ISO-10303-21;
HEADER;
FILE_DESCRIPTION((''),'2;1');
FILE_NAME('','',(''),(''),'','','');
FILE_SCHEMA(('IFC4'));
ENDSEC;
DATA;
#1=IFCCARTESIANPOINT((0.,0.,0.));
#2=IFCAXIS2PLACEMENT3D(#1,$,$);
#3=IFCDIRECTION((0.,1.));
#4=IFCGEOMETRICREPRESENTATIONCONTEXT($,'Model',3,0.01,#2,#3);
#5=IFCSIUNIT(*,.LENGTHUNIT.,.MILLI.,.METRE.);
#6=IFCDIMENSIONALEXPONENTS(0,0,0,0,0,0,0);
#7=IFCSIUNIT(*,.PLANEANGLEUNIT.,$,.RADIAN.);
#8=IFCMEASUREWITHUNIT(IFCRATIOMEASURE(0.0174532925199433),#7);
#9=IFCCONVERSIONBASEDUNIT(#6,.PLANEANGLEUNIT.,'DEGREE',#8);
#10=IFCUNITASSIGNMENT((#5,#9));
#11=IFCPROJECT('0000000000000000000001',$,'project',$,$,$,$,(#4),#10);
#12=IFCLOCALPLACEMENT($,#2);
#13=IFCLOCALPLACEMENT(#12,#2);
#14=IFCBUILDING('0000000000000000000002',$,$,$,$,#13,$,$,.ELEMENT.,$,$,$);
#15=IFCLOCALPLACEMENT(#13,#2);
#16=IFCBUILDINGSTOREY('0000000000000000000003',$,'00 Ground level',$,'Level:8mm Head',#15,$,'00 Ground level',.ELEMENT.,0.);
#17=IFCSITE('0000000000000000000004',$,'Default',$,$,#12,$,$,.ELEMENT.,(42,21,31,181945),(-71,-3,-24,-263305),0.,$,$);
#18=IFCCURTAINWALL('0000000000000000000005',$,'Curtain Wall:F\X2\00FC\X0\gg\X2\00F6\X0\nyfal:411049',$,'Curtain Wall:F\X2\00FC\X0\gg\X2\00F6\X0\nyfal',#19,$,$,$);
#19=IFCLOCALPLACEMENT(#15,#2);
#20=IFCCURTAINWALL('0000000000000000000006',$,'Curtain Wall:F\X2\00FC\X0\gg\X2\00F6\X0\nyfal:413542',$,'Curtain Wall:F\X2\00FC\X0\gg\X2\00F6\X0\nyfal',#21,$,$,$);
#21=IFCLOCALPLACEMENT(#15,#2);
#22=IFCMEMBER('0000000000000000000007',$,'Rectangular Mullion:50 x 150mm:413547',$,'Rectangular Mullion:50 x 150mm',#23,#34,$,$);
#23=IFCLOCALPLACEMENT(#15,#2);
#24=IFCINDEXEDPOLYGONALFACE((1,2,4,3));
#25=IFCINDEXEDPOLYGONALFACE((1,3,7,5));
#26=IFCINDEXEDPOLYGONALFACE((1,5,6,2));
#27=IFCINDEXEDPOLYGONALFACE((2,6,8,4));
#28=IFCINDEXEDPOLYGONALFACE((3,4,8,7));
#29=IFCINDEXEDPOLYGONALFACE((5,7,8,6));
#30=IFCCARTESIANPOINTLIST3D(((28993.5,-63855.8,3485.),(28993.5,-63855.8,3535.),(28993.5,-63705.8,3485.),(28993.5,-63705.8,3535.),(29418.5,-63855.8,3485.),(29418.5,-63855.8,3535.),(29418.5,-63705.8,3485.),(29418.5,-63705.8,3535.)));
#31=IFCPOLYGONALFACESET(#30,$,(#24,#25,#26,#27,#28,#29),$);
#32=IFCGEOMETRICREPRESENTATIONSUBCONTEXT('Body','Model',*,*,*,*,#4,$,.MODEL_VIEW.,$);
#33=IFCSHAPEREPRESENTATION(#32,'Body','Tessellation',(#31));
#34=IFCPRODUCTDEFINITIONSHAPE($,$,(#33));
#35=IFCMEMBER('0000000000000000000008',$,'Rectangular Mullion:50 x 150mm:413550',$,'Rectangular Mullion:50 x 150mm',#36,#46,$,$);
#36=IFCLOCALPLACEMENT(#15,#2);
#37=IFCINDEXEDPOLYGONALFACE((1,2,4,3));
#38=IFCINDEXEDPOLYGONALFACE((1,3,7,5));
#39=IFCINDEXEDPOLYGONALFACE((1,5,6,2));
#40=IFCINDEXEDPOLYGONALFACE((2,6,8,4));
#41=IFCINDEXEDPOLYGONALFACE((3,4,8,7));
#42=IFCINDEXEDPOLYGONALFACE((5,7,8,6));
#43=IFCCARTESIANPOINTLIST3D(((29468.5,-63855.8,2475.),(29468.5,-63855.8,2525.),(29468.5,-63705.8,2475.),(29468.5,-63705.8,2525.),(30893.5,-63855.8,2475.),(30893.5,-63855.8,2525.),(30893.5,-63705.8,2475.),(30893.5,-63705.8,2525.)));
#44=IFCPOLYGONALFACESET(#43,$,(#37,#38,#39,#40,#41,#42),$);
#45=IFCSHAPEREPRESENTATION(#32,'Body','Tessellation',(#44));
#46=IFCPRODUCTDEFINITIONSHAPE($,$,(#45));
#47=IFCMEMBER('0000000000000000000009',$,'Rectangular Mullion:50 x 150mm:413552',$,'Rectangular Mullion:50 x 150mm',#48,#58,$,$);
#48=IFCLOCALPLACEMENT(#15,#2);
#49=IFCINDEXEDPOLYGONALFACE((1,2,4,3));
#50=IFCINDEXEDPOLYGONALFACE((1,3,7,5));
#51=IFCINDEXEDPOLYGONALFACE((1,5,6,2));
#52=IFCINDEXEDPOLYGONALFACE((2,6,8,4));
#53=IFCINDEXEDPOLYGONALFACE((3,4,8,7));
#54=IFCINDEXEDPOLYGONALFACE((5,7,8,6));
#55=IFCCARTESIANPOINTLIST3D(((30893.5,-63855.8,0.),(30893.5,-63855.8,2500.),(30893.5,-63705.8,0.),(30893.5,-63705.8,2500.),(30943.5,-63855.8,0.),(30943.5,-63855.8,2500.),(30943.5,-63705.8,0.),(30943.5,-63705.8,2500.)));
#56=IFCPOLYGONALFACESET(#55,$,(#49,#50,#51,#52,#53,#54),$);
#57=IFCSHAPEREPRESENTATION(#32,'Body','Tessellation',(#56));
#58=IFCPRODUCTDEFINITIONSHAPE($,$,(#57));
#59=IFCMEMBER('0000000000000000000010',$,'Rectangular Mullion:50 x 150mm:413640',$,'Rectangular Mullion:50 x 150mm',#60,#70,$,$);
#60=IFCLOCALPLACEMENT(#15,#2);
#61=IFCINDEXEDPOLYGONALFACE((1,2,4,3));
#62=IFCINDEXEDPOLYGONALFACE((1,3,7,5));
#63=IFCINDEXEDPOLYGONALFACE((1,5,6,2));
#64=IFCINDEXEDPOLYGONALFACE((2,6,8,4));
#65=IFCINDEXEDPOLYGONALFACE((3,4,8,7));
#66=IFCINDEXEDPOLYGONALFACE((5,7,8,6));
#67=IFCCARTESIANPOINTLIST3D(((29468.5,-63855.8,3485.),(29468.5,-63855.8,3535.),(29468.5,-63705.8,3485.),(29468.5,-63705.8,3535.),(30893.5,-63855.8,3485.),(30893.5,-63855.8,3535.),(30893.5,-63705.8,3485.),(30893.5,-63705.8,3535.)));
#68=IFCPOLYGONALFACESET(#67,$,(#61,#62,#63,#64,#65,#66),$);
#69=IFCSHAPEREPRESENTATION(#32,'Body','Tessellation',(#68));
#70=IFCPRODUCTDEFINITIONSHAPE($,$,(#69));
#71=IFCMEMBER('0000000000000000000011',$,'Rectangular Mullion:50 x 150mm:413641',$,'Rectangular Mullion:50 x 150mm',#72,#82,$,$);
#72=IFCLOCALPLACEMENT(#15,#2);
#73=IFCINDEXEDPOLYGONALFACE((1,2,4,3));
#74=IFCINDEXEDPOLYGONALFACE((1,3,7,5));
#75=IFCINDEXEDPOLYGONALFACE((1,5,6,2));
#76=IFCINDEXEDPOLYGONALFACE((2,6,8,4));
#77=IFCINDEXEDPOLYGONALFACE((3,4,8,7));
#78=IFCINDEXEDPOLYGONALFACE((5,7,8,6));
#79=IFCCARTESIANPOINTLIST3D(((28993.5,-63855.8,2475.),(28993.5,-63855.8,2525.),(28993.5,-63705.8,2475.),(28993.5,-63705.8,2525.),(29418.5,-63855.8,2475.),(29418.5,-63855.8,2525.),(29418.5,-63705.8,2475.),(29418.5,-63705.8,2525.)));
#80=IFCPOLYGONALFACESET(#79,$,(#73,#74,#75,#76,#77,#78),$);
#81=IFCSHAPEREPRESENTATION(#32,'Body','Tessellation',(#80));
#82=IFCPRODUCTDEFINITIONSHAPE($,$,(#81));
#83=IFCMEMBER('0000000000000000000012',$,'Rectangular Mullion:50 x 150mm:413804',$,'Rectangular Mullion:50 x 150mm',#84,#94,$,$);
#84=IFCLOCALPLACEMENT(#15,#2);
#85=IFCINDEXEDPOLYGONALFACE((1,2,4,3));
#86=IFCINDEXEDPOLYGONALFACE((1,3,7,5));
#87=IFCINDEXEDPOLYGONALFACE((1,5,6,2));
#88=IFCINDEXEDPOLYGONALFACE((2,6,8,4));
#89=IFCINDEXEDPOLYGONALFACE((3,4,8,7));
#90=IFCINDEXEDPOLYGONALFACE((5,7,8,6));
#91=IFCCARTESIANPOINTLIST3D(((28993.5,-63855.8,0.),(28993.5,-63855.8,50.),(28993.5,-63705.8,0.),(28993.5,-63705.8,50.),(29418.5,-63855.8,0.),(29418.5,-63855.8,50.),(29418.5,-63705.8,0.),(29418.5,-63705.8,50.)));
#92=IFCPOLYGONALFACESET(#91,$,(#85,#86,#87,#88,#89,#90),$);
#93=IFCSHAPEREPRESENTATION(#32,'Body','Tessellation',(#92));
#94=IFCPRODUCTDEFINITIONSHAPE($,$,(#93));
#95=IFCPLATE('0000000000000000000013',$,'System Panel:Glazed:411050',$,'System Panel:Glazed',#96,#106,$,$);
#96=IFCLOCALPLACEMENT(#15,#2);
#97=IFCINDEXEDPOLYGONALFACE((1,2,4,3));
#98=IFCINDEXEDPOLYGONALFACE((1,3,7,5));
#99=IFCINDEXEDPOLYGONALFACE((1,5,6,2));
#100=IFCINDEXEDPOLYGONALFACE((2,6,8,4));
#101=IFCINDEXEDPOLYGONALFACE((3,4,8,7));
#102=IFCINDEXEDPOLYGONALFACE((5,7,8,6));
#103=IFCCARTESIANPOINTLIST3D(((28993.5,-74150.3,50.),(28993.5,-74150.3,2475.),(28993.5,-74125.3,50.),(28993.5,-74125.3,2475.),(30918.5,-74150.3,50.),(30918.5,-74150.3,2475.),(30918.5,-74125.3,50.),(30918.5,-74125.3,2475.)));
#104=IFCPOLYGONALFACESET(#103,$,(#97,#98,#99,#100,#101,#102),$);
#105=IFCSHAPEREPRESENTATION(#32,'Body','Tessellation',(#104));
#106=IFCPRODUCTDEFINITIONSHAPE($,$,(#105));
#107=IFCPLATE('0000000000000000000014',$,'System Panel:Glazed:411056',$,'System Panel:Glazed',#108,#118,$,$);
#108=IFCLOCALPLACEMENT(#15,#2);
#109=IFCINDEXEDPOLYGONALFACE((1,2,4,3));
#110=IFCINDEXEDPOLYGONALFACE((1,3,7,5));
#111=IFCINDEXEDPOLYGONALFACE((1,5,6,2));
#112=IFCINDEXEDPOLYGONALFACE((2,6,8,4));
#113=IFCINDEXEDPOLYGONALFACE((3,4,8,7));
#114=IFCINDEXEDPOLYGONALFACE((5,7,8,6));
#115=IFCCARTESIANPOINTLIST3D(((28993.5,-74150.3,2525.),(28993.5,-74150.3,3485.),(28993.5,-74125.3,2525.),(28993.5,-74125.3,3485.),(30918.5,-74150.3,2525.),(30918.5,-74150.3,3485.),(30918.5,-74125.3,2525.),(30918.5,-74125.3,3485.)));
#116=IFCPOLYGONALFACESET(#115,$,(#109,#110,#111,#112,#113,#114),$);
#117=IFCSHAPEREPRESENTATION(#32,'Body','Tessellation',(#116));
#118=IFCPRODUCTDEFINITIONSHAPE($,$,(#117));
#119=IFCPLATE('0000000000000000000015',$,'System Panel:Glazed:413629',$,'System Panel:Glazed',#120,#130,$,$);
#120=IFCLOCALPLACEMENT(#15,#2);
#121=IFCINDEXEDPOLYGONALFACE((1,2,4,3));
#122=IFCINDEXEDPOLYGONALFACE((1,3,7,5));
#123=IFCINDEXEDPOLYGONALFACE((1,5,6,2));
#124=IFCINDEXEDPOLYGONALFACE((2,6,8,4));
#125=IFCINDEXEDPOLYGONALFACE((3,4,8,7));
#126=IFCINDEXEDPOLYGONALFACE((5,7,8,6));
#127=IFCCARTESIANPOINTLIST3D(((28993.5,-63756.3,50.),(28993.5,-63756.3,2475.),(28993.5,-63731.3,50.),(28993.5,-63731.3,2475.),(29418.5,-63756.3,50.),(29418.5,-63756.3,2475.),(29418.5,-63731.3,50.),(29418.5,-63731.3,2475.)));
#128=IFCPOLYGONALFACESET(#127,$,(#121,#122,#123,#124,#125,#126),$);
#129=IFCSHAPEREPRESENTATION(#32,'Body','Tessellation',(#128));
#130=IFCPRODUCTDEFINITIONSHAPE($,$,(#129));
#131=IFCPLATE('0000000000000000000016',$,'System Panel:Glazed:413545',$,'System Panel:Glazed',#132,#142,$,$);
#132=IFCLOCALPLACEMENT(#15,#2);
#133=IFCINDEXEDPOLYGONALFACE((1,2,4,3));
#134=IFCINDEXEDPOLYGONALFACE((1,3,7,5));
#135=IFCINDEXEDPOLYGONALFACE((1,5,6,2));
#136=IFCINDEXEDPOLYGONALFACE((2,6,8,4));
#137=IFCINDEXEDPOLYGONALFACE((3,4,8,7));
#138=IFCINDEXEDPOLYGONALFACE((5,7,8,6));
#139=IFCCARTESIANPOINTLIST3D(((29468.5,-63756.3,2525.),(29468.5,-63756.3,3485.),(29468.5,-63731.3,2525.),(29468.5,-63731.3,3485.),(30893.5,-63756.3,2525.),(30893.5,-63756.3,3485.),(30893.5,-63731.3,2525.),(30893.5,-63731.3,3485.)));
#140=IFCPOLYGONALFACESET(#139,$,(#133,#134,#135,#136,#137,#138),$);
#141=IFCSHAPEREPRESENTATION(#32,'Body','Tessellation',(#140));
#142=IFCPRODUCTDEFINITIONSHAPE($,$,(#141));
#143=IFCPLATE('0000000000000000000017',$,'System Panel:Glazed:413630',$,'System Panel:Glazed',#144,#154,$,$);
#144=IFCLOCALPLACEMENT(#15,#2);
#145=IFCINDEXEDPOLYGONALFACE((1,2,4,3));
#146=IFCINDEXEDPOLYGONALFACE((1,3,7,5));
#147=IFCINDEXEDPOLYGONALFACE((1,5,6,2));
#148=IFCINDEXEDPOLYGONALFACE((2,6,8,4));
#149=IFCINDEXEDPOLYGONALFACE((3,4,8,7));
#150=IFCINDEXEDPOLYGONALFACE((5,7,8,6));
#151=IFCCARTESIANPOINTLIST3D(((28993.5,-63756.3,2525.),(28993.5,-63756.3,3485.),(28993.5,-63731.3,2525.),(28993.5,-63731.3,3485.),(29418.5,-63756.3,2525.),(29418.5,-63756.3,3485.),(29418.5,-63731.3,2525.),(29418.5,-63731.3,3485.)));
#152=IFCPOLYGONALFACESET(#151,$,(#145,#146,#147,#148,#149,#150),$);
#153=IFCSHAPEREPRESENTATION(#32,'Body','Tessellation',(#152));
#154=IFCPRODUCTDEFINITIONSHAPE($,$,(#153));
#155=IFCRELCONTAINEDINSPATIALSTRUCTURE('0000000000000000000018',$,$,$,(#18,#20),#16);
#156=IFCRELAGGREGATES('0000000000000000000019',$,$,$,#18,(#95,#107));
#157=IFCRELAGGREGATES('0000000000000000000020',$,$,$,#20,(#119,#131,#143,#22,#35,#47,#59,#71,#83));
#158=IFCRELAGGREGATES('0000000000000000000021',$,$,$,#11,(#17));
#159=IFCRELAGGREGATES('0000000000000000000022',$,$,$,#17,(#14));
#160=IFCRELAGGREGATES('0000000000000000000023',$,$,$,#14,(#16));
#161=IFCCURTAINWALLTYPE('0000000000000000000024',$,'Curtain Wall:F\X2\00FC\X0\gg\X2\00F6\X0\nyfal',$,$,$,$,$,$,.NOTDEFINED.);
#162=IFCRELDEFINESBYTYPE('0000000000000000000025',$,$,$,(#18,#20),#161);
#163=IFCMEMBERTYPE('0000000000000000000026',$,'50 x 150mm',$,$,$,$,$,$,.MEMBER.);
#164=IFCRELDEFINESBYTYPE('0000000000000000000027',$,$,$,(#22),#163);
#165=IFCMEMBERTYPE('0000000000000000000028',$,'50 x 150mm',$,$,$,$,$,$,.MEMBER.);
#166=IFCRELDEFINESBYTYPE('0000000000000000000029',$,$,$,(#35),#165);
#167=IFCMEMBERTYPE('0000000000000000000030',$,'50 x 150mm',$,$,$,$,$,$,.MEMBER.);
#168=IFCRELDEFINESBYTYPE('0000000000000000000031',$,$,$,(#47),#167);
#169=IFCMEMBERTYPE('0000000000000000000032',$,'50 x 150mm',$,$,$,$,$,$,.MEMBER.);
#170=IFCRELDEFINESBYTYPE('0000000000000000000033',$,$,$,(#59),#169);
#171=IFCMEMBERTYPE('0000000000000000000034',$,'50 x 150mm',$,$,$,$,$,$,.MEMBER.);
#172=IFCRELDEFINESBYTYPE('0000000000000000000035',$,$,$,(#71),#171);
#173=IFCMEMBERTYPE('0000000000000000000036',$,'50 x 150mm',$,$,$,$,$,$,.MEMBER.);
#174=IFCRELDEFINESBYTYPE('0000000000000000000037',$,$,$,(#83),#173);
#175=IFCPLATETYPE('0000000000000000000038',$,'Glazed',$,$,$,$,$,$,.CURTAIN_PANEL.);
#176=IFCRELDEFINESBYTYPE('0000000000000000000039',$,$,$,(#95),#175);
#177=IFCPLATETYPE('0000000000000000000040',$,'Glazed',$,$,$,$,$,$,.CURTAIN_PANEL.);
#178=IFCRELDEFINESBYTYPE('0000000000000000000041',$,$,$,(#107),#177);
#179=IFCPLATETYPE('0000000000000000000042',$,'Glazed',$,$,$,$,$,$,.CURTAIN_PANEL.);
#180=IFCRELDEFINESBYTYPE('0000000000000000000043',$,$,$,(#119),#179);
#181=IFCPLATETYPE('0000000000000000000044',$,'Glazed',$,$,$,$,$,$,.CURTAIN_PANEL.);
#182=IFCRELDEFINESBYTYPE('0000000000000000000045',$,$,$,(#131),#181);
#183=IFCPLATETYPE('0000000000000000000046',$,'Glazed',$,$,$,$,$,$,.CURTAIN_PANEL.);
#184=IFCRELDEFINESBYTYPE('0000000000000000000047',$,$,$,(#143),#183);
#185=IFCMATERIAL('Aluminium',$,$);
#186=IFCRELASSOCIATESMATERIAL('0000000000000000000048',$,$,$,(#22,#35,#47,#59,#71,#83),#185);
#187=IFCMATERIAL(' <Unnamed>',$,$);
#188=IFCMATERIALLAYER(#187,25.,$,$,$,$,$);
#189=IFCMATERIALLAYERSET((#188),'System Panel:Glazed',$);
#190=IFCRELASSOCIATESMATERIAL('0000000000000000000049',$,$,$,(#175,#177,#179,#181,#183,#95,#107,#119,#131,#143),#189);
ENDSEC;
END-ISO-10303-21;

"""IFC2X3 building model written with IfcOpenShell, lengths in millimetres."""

from ifc_helpers import new_model, entity, si_unit, converted_unit, direction, frame, frame_2d, origin, origin_2d_with_axis, place, context, subcontext, project, spatial, rectangle, extrude, source, transform, mapped, material, layer, layer_set, layer_usage, type_object, type_shapes, element, aggregate, save


model = new_model("IFC2X3")

# Units and contexts
model_context = context("Model", 3, precision=0.01, world=origin(), true_north=direction((0.0, 1.0)))
body_context = subcontext(model_context, "Body", "Model", "MODEL_VIEW")
ifc_project = project(units=[si_unit("LENGTHUNIT", "METRE", prefix="MILLI"), converted_unit("PLANEANGLEUNIT", "DEGREE", entity("IfcRatioMeasure", 0.0174532925199433), si_unit("PLANEANGLEUNIT", "RADIAN"), dimensions=[0, 0, 0, 0, 0, 0, 0])], contexts=[model_context])

# Site, building, storey
site_placement = place(None, origin())
site = spatial("IfcSite", under=ifc_project, at=site_placement, Name="Default", CompositionType="ELEMENT", RefLatitude=(42, 21, 31, 181945), RefLongitude=(-71, -3, -24, -263305), RefElevation=0.0)
building_placement = place(site_placement, origin())
building = spatial("IfcBuilding", under=site, at=building_placement, CompositionType="ELEMENT")
storey_placement = place(building_placement, origin())
storey = spatial("IfcBuildingStorey", under=building, at=storey_placement, Name="00 Ground level", ObjectType="Level:8mm Head", LongName="00 Ground level", CompositionType="ELEMENT", Elevation=0.0)

# Curtain walls
curtain_wall_type = type_object("IfcCurtainWallType", Name="Curtain Wall:Függönyfal", PredefinedType="NOTDEFINED")
curtain_wall_1_placement = place(storey_placement, origin())
curtain_wall_1 = element("IfcCurtainWall", 1, at=curtain_wall_1_placement, inside=storey, type_object=curtain_wall_type, Name="Curtain Wall:Függönyfal:411049", ObjectType="Curtain Wall:Függönyfal")
ifc_material_1 = material(Name="Aluminium")
curtain_wall_2_placement = place(storey_placement, origin())
curtain_wall_2 = element("IfcCurtainWall", 2, at=curtain_wall_2_placement, inside=storey, type_object=curtain_wall_type, Name="Curtain Wall:Függönyfal:413542", ObjectType="Curtain Wall:Függönyfal")

# Members
member_type_1 = type_object("IfcMemberType", Name="50 x 150mm", PredefinedType="MEMBER")
shared_shape_1 = source(origin(), body_context, "Body", "SweptSolid", [
    extrude(rectangle(XDim=150.0, YDim=50.0, at=origin_2d_with_axis()), frame((-25.0, 0.0, -425.0), z_axis=(0.0, 0.0, 1.0), x_axis=(0.0, -1.0, 0.0)), (0.0, 0.0, 1.0), 425.0),
])
type_shapes(member_type_1, [shared_shape_1])
member_1_placement = place(storey_placement, frame((28993.5, -63780.8, 3535.0), z_axis=(-1.0, 0.0, 0.0), x_axis=(0.0, 0.0, 1.0)))
member_1 = element("IfcMember", 3, at=member_1_placement, type_object=member_type_1, material=ifc_material_1, Name="Rectangular Mullion:50 x 150mm:413547", ObjectType="Rectangular Mullion:50 x 150mm", context=body_context, shape_type="MappedRepresentation", body=[
    mapped(shared_shape_1, transform((0.0, 0.0, 0.0), scale=1.0)),
])
member_type_2 = type_object("IfcMemberType", Name="50 x 150mm", PredefinedType="MEMBER")
shared_shape_2 = source(origin(), body_context, "Body", "SweptSolid", [
    extrude(rectangle(XDim=150.0, YDim=50.0, at=origin_2d_with_axis()), frame((0.0, 0.0, -1425.0), z_axis=(0.0, 0.0, 1.0), x_axis=(0.0, -1.0, 0.0)), (0.0, 0.0, 1.0), 1425.0),
])
type_shapes(member_type_2, [shared_shape_2])
member_2_placement = place(storey_placement, frame((29468.5, -63780.8, 2500.0), z_axis=(-1.0, 0.0, 0.0), x_axis=(0.0, 0.0, 1.0)))
member_2 = element("IfcMember", 4, at=member_2_placement, type_object=member_type_2, material=ifc_material_1, Name="Rectangular Mullion:50 x 150mm:413550", ObjectType="Rectangular Mullion:50 x 150mm", context=body_context, shape_type="MappedRepresentation", body=[
    mapped(shared_shape_2, transform((0.0, 0.0, 0.0), scale=1.0)),
])
member_type_3 = type_object("IfcMemberType", Name="50 x 150mm", PredefinedType="MEMBER")
shared_shape_3 = source(origin(), body_context, "Body", "SweptSolid", [
    extrude(rectangle(XDim=150.0, YDim=50.0, at=origin_2d_with_axis()), frame((-25.0, 0.0, -2500.0), z_axis=(0.0, 0.0, 1.0), x_axis=(0.0, -1.0, 0.0)), (0.0, 0.0, 1.0), 2500.0),
])
type_shapes(member_type_3, [shared_shape_3])
member_3_placement = place(storey_placement, frame((30943.5, -63780.8, 2500.0)))
member_3 = element("IfcMember", 5, at=member_3_placement, type_object=member_type_3, material=ifc_material_1, Name="Rectangular Mullion:50 x 150mm:413552", ObjectType="Rectangular Mullion:50 x 150mm", context=body_context, shape_type="MappedRepresentation", body=[
    mapped(shared_shape_3, transform((0.0, 0.0, 0.0), scale=1.0)),
])
member_type_4 = type_object("IfcMemberType", Name="50 x 150mm", PredefinedType="MEMBER")
shared_shape_4 = source(origin(), body_context, "Body", "SweptSolid", [
    extrude(rectangle(XDim=150.0, YDim=50.0, at=origin_2d_with_axis()), frame((-25.0, 0.0, -1425.0), z_axis=(0.0, 0.0, 1.0), x_axis=(0.0, -1.0, 0.0)), (0.0, 0.0, 1.0), 1425.0),
])
type_shapes(member_type_4, [shared_shape_4])
member_4_placement = place(storey_placement, frame((29468.5, -63780.8, 3535.0), z_axis=(-1.0, 0.0, 0.0), x_axis=(0.0, 0.0, 1.0)))
member_4 = element("IfcMember", 6, at=member_4_placement, type_object=member_type_4, material=ifc_material_1, Name="Rectangular Mullion:50 x 150mm:413640", ObjectType="Rectangular Mullion:50 x 150mm", context=body_context, shape_type="MappedRepresentation", body=[
    mapped(shared_shape_4, transform((0.0, 0.0, 0.0), scale=1.0)),
])
member_type_5 = type_object("IfcMemberType", Name="50 x 150mm", PredefinedType="MEMBER")
shared_shape_5 = source(origin(), body_context, "Body", "SweptSolid", [
    extrude(rectangle(XDim=150.0, YDim=50.0, at=origin_2d_with_axis()), frame((0.0, 0.0, -425.0), z_axis=(0.0, 0.0, 1.0), x_axis=(0.0, -1.0, 0.0)), (0.0, 0.0, 1.0), 425.0),
])
type_shapes(member_type_5, [shared_shape_5])
member_5_placement = place(storey_placement, frame((28993.5, -63780.8, 2500.0), z_axis=(-1.0, 0.0, 0.0), x_axis=(0.0, 0.0, 1.0)))
member_5 = element("IfcMember", 7, at=member_5_placement, type_object=member_type_5, material=ifc_material_1, Name="Rectangular Mullion:50 x 150mm:413641", ObjectType="Rectangular Mullion:50 x 150mm", context=body_context, shape_type="MappedRepresentation", body=[
    mapped(shared_shape_5, transform((0.0, 0.0, 0.0), scale=1.0)),
])
member_type_6 = type_object("IfcMemberType", Name="50 x 150mm", PredefinedType="MEMBER")
shared_shape_6 = source(origin(), body_context, "Body", "SweptSolid", [
    extrude(rectangle(XDim=150.0, YDim=50.0, at=origin_2d_with_axis()), frame((-25.0, 0.0, -425.0), z_axis=(0.0, 0.0, 1.0), x_axis=(0.0, -1.0, 0.0)), (0.0, 0.0, 1.0), 425.0),
])
type_shapes(member_type_6, [shared_shape_6])
member_6_placement = place(storey_placement, frame((29418.5, -63780.8, 0.0), z_axis=(1.0, 0.0, 0.0), x_axis=(0.0, 0.0, -1.0)))
member_6 = element("IfcMember", 8, at=member_6_placement, type_object=member_type_6, material=ifc_material_1, Name="Rectangular Mullion:50 x 150mm:413804", ObjectType="Rectangular Mullion:50 x 150mm", context=body_context, shape_type="MappedRepresentation", body=[
    mapped(shared_shape_6, transform((0.0, 0.0, 0.0), scale=1.0)),
])

# Plates
ifc_material_2 = material(Name=" <Unnamed>")
ifc_layer_1 = layer(ifc_material_2, 25.0)
ifc_layer_set_1 = layer_set([ifc_layer_1], Name="System Panel:Glazed")
ifc_layer_usage_1 = layer_usage(ifc_layer_set_1, "AXIS3", "POSITIVE", 0.1)
plate_type_1 = type_object("IfcPlateType", Name="Glazed", PredefinedType="CURTAIN_PANEL", material=ifc_layer_set_1)
shared_shape_7 = source(origin(), body_context, "Body", "SweptSolid", [
    extrude(rectangle(XDim=25.0, YDim=1925.0, at=frame_2d((0.0, 0.0), x_axis=(1.0, 0.0))), frame((962.5, 12.5, 0.0), z_axis=(0.0, 0.0, 1.0), x_axis=(0.0, 1.0, 0.0)), (0.0, 0.0, 1.0), 2425.0),
])
type_shapes(plate_type_1, [shared_shape_7])
plate_1_placement = place(curtain_wall_1_placement, frame((28993.5, -74150.3, 50.0)))
plate_1 = element("IfcPlate", 9, at=plate_1_placement, type_object=plate_type_1, material=ifc_layer_usage_1, Name="System Panel:Glazed:411050", ObjectType="System Panel:Glazed", context=body_context, shape_type="MappedRepresentation", body=[
    mapped(shared_shape_7, transform((0.0, 0.0, 0.0), scale=1.0)),
])
ifc_layer_usage_2 = layer_usage(ifc_layer_set_1, "AXIS3", "POSITIVE", 0.1)
plate_type_2 = type_object("IfcPlateType", Name="Glazed", PredefinedType="CURTAIN_PANEL", material=ifc_layer_set_1)
shared_shape_8 = source(origin(), body_context, "Body", "SweptSolid", [
    extrude(rectangle(XDim=25.0, YDim=1925.0, at=frame_2d((0.0, 0.0), x_axis=(1.0, 0.0))), frame((962.5, 12.5, 0.0), z_axis=(0.0, 0.0, 1.0), x_axis=(0.0, 1.0, 0.0)), (0.0, 0.0, 1.0), 960.0),
])
type_shapes(plate_type_2, [shared_shape_8])
plate_2_placement = place(curtain_wall_1_placement, frame((28993.5, -74150.3, 2525.0)))
plate_2 = element("IfcPlate", 10, at=plate_2_placement, type_object=plate_type_2, material=ifc_layer_usage_2, Name="System Panel:Glazed:411056", ObjectType="System Panel:Glazed", context=body_context, shape_type="MappedRepresentation", body=[
    mapped(shared_shape_8, transform((0.0, 0.0, 0.0), scale=1.0)),
])
aggregate(curtain_wall_1, [plate_1, plate_2])
ifc_layer_usage_3 = layer_usage(ifc_layer_set_1, "AXIS3", "POSITIVE", 0.1)
plate_type_3 = type_object("IfcPlateType", Name="Glazed", PredefinedType="CURTAIN_PANEL", material=ifc_layer_set_1)
shared_shape_9 = source(origin(), body_context, "Body", "SweptSolid", [
    extrude(rectangle(XDim=25.0, YDim=425.0, at=frame_2d((0.0, 0.0), x_axis=(1.0, 0.0))), frame((212.5, 12.5, 0.0), z_axis=(0.0, 0.0, 1.0), x_axis=(0.0, 1.0, 0.0)), (0.0, 0.0, 1.0), 2425.0),
])
type_shapes(plate_type_3, [shared_shape_9])
plate_3_placement = place(curtain_wall_2_placement, frame((29418.5, -63731.3, 50.0), z_axis=(0.0, 0.0, 1.0), x_axis=(-1.0, 0.0, 0.0)))
plate_3 = element("IfcPlate", 11, at=plate_3_placement, type_object=plate_type_3, material=ifc_layer_usage_3, Name="System Panel:Glazed:413629", ObjectType="System Panel:Glazed", context=body_context, shape_type="MappedRepresentation", body=[
    mapped(shared_shape_9, transform((0.0, 0.0, 0.0), scale=1.0)),
])
ifc_layer_usage_4 = layer_usage(ifc_layer_set_1, "AXIS3", "POSITIVE", 0.1)
plate_type_4 = type_object("IfcPlateType", Name="Glazed", PredefinedType="CURTAIN_PANEL", material=ifc_layer_set_1)
shared_shape_10 = source(origin(), body_context, "Body", "SweptSolid", [
    extrude(rectangle(XDim=25.0, YDim=1425.0, at=frame_2d((0.0, 0.0), x_axis=(1.0, 0.0))), frame((712.5, 12.5, 0.0), z_axis=(0.0, 0.0, 1.0), x_axis=(0.0, 1.0, 0.0)), (0.0, 0.0, 1.0), 960.0),
])
type_shapes(plate_type_4, [shared_shape_10])
plate_4_placement = place(curtain_wall_2_placement, frame((30893.5, -63731.3, 2525.0), z_axis=(0.0, 0.0, 1.0), x_axis=(-1.0, 0.0, 0.0)))
plate_4 = element("IfcPlate", 12, at=plate_4_placement, type_object=plate_type_4, material=ifc_layer_usage_4, Name="System Panel:Glazed:413545", ObjectType="System Panel:Glazed", context=body_context, shape_type="MappedRepresentation", body=[
    mapped(shared_shape_10, transform((0.0, 0.0, 0.0), scale=1.0)),
])
ifc_layer_usage_5 = layer_usage(ifc_layer_set_1, "AXIS3", "POSITIVE", 0.1)
plate_type_5 = type_object("IfcPlateType", Name="Glazed", PredefinedType="CURTAIN_PANEL", material=ifc_layer_set_1)
shared_shape_11 = source(origin(), body_context, "Body", "SweptSolid", [
    extrude(rectangle(XDim=25.0, YDim=425.0, at=frame_2d((0.0, 0.0), x_axis=(1.0, 0.0))), frame((212.5, 12.5, 0.0), z_axis=(0.0, 0.0, 1.0), x_axis=(0.0, 1.0, 0.0)), (0.0, 0.0, 1.0), 960.0),
])
type_shapes(plate_type_5, [shared_shape_11])
plate_5_placement = place(curtain_wall_2_placement, frame((29418.5, -63731.3, 2525.0), z_axis=(0.0, 0.0, 1.0), x_axis=(-1.0, 0.0, 0.0)))
plate_5 = element("IfcPlate", 13, at=plate_5_placement, type_object=plate_type_5, material=ifc_layer_usage_5, Name="System Panel:Glazed:413630", ObjectType="System Panel:Glazed", context=body_context, shape_type="MappedRepresentation", body=[
    mapped(shared_shape_11, transform((0.0, 0.0, 0.0), scale=1.0)),
])

aggregate(curtain_wall_2, [plate_3, plate_4, plate_5, member_1, member_2, member_3, member_4, member_5, member_6])

save(model, "model.ifc")
